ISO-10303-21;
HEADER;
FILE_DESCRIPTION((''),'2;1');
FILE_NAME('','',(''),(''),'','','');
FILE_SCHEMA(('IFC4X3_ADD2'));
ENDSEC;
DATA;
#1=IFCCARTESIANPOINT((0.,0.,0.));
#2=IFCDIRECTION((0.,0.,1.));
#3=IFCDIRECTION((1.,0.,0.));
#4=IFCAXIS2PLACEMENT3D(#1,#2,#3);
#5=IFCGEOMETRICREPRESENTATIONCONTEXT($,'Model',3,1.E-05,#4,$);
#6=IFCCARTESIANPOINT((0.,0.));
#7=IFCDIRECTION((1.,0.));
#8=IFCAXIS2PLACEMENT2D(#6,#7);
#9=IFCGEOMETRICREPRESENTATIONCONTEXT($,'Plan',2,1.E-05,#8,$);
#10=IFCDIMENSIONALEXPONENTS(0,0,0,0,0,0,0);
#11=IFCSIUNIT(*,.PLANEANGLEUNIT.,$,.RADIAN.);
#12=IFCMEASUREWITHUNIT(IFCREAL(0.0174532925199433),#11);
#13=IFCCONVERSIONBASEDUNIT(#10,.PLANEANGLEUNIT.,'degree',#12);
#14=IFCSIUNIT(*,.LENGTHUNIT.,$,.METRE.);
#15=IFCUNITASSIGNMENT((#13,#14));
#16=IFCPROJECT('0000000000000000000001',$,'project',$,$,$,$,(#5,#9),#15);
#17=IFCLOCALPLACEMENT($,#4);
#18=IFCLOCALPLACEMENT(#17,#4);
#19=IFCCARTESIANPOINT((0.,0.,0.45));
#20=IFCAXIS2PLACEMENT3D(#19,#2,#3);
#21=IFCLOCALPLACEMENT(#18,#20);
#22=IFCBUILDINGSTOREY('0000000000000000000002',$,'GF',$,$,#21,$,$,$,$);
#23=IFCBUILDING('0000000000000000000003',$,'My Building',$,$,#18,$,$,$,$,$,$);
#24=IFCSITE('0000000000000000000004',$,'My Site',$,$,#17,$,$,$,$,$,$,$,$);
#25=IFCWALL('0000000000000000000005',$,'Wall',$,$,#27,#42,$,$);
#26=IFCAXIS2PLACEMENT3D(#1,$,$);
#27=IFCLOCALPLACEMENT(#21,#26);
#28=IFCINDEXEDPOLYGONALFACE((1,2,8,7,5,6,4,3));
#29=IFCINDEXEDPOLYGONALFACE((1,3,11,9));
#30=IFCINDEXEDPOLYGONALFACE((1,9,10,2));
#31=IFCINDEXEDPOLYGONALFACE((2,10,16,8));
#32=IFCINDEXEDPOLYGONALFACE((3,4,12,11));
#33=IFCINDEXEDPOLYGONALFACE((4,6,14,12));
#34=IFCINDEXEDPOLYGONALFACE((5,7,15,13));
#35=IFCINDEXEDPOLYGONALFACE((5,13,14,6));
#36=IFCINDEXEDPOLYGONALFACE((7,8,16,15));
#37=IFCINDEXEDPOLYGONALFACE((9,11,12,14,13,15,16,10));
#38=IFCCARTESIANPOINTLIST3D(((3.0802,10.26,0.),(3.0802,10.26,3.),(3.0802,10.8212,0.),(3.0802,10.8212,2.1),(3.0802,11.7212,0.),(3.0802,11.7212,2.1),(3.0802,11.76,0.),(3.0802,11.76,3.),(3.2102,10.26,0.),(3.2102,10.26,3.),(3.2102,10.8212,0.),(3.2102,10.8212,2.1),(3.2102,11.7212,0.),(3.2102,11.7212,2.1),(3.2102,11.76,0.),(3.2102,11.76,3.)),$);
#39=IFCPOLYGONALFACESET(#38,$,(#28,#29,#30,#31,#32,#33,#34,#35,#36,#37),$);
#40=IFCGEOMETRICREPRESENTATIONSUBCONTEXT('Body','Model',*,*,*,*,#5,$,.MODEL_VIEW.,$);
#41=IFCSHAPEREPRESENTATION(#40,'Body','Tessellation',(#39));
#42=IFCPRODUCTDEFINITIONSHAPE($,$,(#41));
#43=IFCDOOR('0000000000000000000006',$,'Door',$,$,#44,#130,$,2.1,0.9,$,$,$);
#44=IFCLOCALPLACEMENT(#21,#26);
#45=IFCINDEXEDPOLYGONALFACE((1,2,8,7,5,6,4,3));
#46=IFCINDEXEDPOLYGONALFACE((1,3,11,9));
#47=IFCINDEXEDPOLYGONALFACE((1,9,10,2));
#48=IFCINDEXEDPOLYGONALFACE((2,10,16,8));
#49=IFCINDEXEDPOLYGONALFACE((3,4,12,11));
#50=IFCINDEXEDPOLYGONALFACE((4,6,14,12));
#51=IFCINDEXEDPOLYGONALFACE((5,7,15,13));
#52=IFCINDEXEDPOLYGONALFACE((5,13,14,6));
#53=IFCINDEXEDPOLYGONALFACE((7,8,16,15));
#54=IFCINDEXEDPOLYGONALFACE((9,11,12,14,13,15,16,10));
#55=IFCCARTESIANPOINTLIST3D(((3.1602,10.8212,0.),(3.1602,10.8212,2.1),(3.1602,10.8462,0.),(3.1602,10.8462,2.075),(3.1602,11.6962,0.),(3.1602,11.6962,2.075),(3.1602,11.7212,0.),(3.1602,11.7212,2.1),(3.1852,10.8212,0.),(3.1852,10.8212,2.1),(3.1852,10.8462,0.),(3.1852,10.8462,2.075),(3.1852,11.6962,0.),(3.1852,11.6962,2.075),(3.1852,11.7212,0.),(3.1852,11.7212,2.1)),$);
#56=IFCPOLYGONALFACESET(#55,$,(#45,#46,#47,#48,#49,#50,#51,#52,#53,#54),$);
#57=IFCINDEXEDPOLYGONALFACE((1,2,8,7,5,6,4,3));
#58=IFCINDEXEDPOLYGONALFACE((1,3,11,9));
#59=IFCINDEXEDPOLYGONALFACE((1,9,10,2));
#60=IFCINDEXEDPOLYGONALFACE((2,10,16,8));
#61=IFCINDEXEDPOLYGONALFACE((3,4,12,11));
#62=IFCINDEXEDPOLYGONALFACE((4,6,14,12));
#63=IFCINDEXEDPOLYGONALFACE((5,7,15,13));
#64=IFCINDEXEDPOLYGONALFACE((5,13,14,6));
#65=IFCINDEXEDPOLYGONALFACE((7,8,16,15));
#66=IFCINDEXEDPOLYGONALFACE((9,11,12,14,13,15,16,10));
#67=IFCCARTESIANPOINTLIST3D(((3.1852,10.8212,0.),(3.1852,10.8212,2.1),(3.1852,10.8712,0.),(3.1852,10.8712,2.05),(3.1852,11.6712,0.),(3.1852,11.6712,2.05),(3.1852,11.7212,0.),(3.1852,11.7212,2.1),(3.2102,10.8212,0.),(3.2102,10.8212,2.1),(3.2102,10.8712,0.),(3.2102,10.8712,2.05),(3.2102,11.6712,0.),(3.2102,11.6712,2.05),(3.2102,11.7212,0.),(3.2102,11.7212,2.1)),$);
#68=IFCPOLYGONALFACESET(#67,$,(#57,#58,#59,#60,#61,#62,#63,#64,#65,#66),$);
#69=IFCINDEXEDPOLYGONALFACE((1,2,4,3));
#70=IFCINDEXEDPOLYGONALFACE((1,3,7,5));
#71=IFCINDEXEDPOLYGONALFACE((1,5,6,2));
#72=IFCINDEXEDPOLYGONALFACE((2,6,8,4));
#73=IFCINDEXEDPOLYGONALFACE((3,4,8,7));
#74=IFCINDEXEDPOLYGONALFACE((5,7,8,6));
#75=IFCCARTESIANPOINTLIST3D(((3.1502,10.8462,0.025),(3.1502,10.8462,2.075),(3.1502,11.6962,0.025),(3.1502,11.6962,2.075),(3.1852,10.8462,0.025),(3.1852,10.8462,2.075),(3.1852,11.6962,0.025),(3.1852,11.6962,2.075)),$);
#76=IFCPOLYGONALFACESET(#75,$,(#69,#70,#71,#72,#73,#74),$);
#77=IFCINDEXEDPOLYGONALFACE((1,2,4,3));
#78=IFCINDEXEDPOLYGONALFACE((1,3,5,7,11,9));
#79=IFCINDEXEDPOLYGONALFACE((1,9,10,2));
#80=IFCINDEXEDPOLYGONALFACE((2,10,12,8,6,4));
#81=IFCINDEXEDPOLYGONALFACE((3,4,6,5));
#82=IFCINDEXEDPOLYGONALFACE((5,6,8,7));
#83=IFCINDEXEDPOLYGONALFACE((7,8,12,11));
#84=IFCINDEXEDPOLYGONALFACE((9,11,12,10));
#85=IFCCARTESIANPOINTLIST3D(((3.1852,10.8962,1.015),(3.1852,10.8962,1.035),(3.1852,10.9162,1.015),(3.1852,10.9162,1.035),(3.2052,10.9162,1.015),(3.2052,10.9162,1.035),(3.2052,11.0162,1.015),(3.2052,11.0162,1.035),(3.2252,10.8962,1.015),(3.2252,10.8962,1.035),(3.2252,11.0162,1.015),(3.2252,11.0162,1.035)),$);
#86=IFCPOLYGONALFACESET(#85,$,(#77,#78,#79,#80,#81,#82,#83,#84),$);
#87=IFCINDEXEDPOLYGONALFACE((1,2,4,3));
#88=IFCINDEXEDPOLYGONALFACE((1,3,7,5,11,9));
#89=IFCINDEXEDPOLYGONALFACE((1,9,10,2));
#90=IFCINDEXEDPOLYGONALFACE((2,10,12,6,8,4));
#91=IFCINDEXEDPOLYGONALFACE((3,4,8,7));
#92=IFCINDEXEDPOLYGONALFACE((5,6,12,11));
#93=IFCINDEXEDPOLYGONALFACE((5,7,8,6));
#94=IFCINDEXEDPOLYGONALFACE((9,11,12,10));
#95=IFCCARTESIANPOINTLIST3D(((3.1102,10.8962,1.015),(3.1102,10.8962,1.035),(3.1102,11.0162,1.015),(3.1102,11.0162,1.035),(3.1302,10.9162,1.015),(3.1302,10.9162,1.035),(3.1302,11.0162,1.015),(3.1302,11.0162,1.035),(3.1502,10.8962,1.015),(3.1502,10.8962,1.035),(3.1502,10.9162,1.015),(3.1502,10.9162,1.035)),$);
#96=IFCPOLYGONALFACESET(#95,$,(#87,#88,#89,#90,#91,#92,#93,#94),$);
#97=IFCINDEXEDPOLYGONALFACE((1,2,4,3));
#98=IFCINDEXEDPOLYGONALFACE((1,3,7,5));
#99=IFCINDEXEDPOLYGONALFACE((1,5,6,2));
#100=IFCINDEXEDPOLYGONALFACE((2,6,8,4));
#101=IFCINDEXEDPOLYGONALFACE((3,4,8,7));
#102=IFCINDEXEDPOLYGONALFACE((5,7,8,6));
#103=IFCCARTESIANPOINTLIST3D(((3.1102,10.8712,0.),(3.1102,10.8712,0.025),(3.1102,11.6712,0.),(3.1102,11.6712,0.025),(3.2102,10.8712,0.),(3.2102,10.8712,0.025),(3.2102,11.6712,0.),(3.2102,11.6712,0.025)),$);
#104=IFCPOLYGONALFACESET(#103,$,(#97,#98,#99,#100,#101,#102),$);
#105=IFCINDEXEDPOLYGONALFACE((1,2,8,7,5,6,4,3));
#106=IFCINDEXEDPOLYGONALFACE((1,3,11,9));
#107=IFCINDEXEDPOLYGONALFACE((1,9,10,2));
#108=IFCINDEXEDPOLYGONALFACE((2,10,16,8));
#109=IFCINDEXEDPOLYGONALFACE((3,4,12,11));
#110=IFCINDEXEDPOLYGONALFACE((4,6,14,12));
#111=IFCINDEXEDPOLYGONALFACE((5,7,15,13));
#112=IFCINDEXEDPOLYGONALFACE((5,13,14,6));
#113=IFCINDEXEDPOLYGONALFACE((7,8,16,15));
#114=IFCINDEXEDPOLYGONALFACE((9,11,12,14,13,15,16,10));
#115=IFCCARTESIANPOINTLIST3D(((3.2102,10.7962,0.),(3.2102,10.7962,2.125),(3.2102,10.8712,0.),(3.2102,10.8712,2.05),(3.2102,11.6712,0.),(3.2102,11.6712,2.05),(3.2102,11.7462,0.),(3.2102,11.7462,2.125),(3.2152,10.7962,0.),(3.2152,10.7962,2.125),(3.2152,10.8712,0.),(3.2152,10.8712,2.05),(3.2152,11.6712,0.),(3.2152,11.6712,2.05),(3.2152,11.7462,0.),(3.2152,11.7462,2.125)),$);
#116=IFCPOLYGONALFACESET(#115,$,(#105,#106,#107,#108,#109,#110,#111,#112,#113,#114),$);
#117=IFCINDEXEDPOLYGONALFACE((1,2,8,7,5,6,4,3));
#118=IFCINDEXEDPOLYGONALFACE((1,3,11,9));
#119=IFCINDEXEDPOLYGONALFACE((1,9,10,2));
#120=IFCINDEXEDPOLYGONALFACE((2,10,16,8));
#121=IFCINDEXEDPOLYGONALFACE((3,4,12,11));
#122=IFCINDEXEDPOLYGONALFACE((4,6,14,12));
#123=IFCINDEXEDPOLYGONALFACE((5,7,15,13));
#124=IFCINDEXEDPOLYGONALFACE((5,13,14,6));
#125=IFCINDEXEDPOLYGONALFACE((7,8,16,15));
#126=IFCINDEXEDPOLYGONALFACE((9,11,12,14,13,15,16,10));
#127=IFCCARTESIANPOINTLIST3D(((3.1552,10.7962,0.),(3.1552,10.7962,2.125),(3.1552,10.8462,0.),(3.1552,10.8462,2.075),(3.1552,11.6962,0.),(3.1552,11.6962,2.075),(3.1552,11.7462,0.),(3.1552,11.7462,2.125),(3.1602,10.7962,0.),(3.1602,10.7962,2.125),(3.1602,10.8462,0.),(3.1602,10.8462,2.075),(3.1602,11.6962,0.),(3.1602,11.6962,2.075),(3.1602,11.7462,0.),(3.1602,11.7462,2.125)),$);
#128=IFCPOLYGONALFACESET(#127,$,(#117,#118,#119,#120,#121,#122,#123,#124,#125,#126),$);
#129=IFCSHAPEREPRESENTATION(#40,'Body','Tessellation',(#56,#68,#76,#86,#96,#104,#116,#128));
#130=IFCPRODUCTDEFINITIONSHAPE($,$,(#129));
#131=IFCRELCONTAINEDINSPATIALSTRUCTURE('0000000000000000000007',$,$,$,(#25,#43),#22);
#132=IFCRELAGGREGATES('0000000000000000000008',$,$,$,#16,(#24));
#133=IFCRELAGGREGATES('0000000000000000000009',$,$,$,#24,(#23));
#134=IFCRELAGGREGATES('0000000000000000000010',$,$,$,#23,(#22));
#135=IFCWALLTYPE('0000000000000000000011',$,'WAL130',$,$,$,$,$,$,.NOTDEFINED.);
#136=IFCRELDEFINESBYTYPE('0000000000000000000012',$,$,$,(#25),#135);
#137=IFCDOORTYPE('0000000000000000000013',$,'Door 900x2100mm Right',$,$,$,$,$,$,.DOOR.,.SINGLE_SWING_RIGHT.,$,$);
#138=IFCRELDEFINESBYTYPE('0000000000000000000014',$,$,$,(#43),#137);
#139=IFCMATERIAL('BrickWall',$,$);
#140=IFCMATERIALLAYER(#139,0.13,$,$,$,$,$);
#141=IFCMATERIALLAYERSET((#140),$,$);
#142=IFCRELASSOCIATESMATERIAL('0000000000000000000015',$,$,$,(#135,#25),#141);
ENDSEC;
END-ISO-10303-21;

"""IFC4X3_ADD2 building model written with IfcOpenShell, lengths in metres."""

from ifc_helpers import new_model, entity, si_unit, converted_unit, frame, origin_with_axes, origin_2d_with_axis, place, context, subcontext, project, spatial, line, indexed_curve, outline, extrude, shape, source, transform, mapped, material, layer, layer_set, layer_usage, type_object, type_shapes, element, fill, save


model = new_model("IFC4X3_ADD2")

# Units and contexts
model_context = context("Model", 3, precision=1e-05, world=origin_with_axes())
plan_context = context("Plan", 2, precision=1e-05, world=origin_2d_with_axis())
body_context_1 = subcontext(model_context, "Body", "Model", "MODEL_VIEW")
body_context_2 = subcontext(plan_context, "Body", "Plan", "PLAN_VIEW")
ifc_project = project(units=[converted_unit("PLANEANGLEUNIT", "degree", entity("IfcReal", 0.0174532925199433), si_unit("PLANEANGLEUNIT", "RADIAN"), dimensions=[0, 0, 0, 0, 0, 0, 0]), si_unit("LENGTHUNIT", "METRE")], contexts=[model_context, plan_context])

# Site, building, storey
site_placement = place(None, origin_with_axes())
site = spatial("IfcSite", under=ifc_project, at=site_placement, Name="My Site")
building_placement = place(site_placement, origin_with_axes())
building = spatial("IfcBuilding", under=site, at=building_placement, Name="My Building")
storey_placement = place(building_placement, frame((0.0, 0.0, 0.45), z_axis=(0.0, 0.0, 1.0), x_axis=(1.0, 0.0, 0.0)))
storey = spatial("IfcBuildingStorey", under=building, at=storey_placement, Name="GF")

# Shared definitions
ifc_material_1 = material(Name="BrickWall")

# Shared definitions
ifc_layer_1 = layer(ifc_material_1, 0.13)
ifc_layer_set_1 = layer_set([ifc_layer_1])
wall_type_1 = type_object("IfcWallType", Name="WAL130", PredefinedType="NOTDEFINED", material=ifc_layer_set_1)

# Wall, opening, door
ifc_layer_usage_1 = layer_usage(ifc_layer_set_1, "AXIS2", "POSITIVE", 0.0)
wall_1_placement = place(storey_placement, frame((3.2102, 10.26, 0.0), z_axis=(0.0, 0.0, 1.0), x_axis=(0.0, 1.0, 0.0)))
wall_1 = element("IfcWall", 1, at=wall_1_placement, inside=storey, type_object=wall_type_1, material=ifc_layer_usage_1, Name="Wall", context=body_context_1, shape_type="SweptSolid", body=[
    extrude(outline(indexed_curve([(0.0, 0.0), (0.0, 0.13), (1.5, 0.13), (1.5, 0.0), (0.0, 0.0)], self_intersect=False)), origin_with_axes(), (0.0, 0.0, 1.0), 3.0),
])
shared_shape_1 = source(origin_with_axes(), body_context_1, "Body", "SweptSolid", [
    extrude(outline(indexed_curve([(0.0, 0.0), (0.9, 0.0), (0.9, 2.1), (0.0, 2.1)], segments=[line(1, 2, 3, 4, 1)])), frame((0.0, -0.6, 0.0), z_axis=(0.0, -1.0, 0.0), x_axis=(1.0, 0.0, 0.0)), (0.0, 0.0, -1.0), 1.2),
])
opening_1_placement = place(wall_1_placement, frame((0.5612, 0.0, 0.0), z_axis=(0.0, 0.0, 1.0), x_axis=(1.0, 0.0, 0.0)))
opening_1 = element("IfcOpeningElement", 2, at=opening_1_placement, cuts=wall_1, PredefinedType="OPENING", context=body_context_1, shape_type="MappedRepresentation", body=[
    mapped(shared_shape_1, transform((0.0, 0.0, 0.0), x_axis=(1.0, 0.0, 0.0), y_axis=(0.0, 1.0, 0.0), z_axis=(0.0, 0.0, 1.0), scale=1.0)),
])
door_type_1 = type_object("IfcDoorType", Name="Door 900x2100mm Right", OperationType="SINGLE_SWING_RIGHT", PredefinedType="DOOR")
shared_shape_2 = source(origin_with_axes(), body_context_1, "Body", "SweptSolid", [
    extrude(outline(indexed_curve([(0.0, 0.0), (0.0, 2.1), (0.9, 2.1), (0.9, 0.0), (0.875, 0.0), (0.875, 2.075), (0.025, 2.075), (0.025, 0.0)], segments=[line(1, 2, 3, 4, 5, 6, 7, 8, 1)])), frame((0.0, 0.025, 0.0), z_axis=(0.0, -1.0, 0.0), x_axis=(1.0, 0.0, 0.0)), (0.0, 0.0, -1.0), 0.025),
    extrude(outline(indexed_curve([(0.0, 0.0), (0.0, 2.1), (0.9, 2.1), (0.9, 0.0), (0.85, 0.0), (0.85, 2.05), (0.05, 2.05), (0.05, 0.0)], segments=[line(1, 2, 3, 4, 5, 6, 7, 8, 1)])), frame((0.0, 0.0, 0.0), z_axis=(0.0, -1.0, 0.0), x_axis=(1.0, 0.0, 0.0)), (0.0, 0.0, -1.0), 0.025),
    extrude(outline(indexed_curve([(0.0, 0.0), (0.85, 0.0), (0.85, 0.035), (0.0, 0.035)], segments=[line(1, 2, 3, 4, 1)])), frame((0.025, 0.025, 0.025), z_axis=(0.0, 0.0, 1.0), x_axis=(1.0, 0.0, 0.0)), (0.0, 0.0, 1.0), 2.05),
    extrude(outline(indexed_curve([(0.0, 0.0), (0.0, -0.04), (0.12, -0.04), (0.12, -0.02), (0.02, -0.02), (0.02, 0.0)], segments=[line(1, 2, 3, 4, 5, 6, 1)])), frame((0.075, 0.025, 1.015), z_axis=(0.0, 0.0, 1.0), x_axis=(1.0, 0.0, 0.0)), (0.0, 0.0, 1.0), 0.02),
    extrude(outline(indexed_curve([(0.0, 0.0), (0.0, 0.04), (0.12, 0.04), (0.12, 0.02), (0.02, 0.02), (0.02, 0.0)], segments=[line(1, 2, 3, 4, 5, 6, 1)])), frame((0.075, 0.06, 1.015), z_axis=(0.0, 0.0, 1.0), x_axis=(1.0, 0.0, 0.0)), (0.0, 0.0, 1.0), 0.02),
    extrude(outline(indexed_curve([(0.0, 0.0), (0.8, 0.0), (0.8, 0.1), (0.0, 0.1)], segments=[line(1, 2, 3, 4, 1)])), frame((0.05, 0.0, 0.0), z_axis=(0.0, 0.0, 1.0), x_axis=(1.0, 0.0, 0.0)), (0.0, 0.0, 1.0), 0.025),
    extrude(outline(indexed_curve([(0.0, 0.0), (0.0, 2.125), (0.95, 2.125), (0.95, 0.0), (0.875, 0.0), (0.875, 2.05), (0.075, 2.05), (0.075, 0.0)], segments=[line(1, 2, 3, 4, 5, 6, 7, 8, 1)])), frame((-0.025, -0.005, 0.0), z_axis=(0.0, -1.0, 0.0), x_axis=(1.0, 0.0, 0.0)), (0.0, 0.0, -1.0), 0.005),
    extrude(outline(indexed_curve([(0.0, 0.0), (0.0, 2.125), (0.95, 2.125), (0.95, 0.0), (0.9, 0.0), (0.9, 2.075), (0.05, 2.075), (0.05, 0.0)], segments=[line(1, 2, 3, 4, 5, 6, 7, 8, 1)])), frame((-0.025, 0.05, 0.0), z_axis=(0.0, -1.0, 0.0), x_axis=(1.0, 0.0, 0.0)), (0.0, 0.0, -1.0), 0.005),
])
shared_shape_3 = source(origin_with_axes(), body_context_2, "Body", "Curve2D", [
    entity("IfcIndexedPolyCurve", entity("IfcCartesianPointList2D", [[0.0, 0.0], [0.0, 0.05], [0.025, 0.05], [0.025, 0.025], [0.05, 0.025], [0.05, 0.0]]), [entity("IfcLineIndex", [1, 2, 3, 4, 5, 6, 1])]),
    entity("IfcIndexedPolyCurve", entity("IfcCartesianPointList2D", [[0.9, 0.0], [0.9, 0.05], [0.875, 0.05], [0.875, 0.025], [0.85, 0.025], [0.85, 0.0]]), [entity("IfcLineIndex", [1, 2, 3, 4, 5, 6, 1])]),
    entity("IfcTrimmedCurve", entity("IfcEllipse", entity("IfcAxis2Placement2D", entity("IfcCartesianPoint", [0.84, 0.05]), entity("IfcDirection", [1.0, 0.0])), 0.815, 0.85), [entity("IfcCartesianPoint", [0.84, 0.9])], [entity("IfcCartesianPoint", [0.025, 0.05])], True, "CARTESIAN"),
    entity("IfcIndexedPolyCurve", entity("IfcCartesianPointList2D", [[0.875, 0.05], [0.84, 0.05], [0.84, 0.9], [0.875, 0.9]]), [entity("IfcLineIndex", [1, 2, 3, 4, 1])]),
])
type_shapes(door_type_1, [shared_shape_2, shared_shape_3])
door_1_placement = place(opening_1_placement, frame((0.0, 0.0, 0.0), z_axis=(0.0, 0.0, 1.0), x_axis=(1.0, 0.0, 0.0)))
door_1 = element("IfcDoor", 3, at=door_1_placement, inside=storey, type_object=door_type_1, Name="Door", OverallHeight=2.1, OverallWidth=0.9, shapes=[
    shape(body_context_1, "Body", "MappedRepresentation", [mapped(shared_shape_2, transform((0.0, 0.0, 0.0), x_axis=(1.0, 0.0, 0.0), y_axis=(0.0, 1.0, 0.0), z_axis=(0.0, 0.0, 1.0), scale=1.0))]),
    shape(body_context_2, "Body", "MappedRepresentation", [mapped(shared_shape_3, transform((0.0, 0.0, 0.0), x_axis=(1.0, 0.0, 0.0), y_axis=(0.0, 1.0, 0.0), z_axis=(0.0, 0.0, 1.0), scale=1.0))]),
])
fill(opening_1, door_1)

save(model, "model.ifc")
